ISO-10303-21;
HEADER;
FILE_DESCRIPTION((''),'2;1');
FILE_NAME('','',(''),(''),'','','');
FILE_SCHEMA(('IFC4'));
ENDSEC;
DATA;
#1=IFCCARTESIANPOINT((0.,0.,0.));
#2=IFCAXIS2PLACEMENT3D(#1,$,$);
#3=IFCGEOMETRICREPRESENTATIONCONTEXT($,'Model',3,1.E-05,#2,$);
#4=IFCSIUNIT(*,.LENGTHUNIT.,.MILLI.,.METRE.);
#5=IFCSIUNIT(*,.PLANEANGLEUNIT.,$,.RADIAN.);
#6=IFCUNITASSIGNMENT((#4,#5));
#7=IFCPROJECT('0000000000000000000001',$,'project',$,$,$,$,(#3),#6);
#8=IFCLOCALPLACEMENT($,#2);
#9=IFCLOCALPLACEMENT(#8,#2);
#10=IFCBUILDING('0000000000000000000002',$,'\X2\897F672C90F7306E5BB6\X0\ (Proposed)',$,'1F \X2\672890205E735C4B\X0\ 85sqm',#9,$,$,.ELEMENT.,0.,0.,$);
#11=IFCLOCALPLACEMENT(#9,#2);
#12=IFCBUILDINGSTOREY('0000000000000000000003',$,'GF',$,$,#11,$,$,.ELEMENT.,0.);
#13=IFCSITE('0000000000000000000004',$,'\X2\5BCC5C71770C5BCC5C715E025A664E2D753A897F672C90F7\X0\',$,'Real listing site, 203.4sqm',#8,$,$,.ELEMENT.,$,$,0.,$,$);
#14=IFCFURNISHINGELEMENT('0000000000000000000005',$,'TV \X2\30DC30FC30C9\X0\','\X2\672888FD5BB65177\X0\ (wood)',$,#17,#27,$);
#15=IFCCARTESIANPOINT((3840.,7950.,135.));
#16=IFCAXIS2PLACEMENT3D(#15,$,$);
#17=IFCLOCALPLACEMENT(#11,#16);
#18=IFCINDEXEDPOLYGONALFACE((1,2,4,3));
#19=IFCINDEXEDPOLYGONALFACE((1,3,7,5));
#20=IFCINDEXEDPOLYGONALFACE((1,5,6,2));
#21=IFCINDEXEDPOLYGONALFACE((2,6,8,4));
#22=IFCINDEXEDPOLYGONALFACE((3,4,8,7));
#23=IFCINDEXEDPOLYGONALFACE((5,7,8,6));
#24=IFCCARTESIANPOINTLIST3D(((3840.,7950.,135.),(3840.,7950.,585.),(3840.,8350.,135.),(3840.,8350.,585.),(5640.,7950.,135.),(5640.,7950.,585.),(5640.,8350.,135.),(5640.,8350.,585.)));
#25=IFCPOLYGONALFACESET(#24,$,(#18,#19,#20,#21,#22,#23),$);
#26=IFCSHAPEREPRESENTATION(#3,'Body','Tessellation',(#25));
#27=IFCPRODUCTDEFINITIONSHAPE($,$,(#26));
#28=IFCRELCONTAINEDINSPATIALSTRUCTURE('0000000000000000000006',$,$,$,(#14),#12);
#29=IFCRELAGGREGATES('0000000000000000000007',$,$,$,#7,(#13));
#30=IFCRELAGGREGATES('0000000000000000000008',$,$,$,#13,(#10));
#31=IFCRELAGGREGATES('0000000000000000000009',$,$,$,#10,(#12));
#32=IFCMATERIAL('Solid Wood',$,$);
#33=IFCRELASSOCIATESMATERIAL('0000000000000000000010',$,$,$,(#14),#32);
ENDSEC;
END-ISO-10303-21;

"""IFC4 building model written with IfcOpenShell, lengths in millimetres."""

from ifc_helpers import new_model, si_unit, frame, frame_2d, origin, place, context, project, spatial, rectangle, extrude, material, element, save


model = new_model("IFC4")

# Units and contexts
model_context = context("Model", 3, precision=1e-05, world=origin())
ifc_project = project(units=[si_unit("LENGTHUNIT", "METRE", prefix="MILLI"), si_unit("PLANEANGLEUNIT", "RADIAN")], contexts=[model_context])

# Site, building, storey
site_placement = place(None, origin())
site = spatial("IfcSite", under=ifc_project, at=site_placement, Name="富山県富山市婦中町西本郷", ObjectType="Real listing site, 203.4sqm", CompositionType="ELEMENT", RefElevation=0.0)
building_placement = place(site_placement, origin())
building = spatial("IfcBuilding", under=site, at=building_placement, Name="西本郷の家 (Proposed)", ObjectType="1F 木造平屋 85sqm", CompositionType="ELEMENT", ElevationOfRefHeight=0.0, ElevationOfTerrain=0.0)
storey_placement = place(building_placement, origin())
storey = spatial("IfcBuildingStorey", under=building, at=storey_placement, Name="GF", CompositionType="ELEMENT", Elevation=0.0)

# Shared definitions
ifc_material_1 = material(Name="Solid Wood")

# Furnishing element
furnishing_1_placement = place(storey_placement, frame((3840.0, 7950.0, 135.0)))
element("IfcFurnishingElement", 1, at=furnishing_1_placement, inside=storey, material=ifc_material_1, Name="TV ボード", Description="木製家具 (wood)", context=model_context, shape_type="SweptSolid", body=[
    extrude(rectangle(XDim=1800.0, YDim=400.0, at=frame_2d((900.0, 200.0))), frame((3840.0, 7950.0, 135.0)), (0.0, 0.0, 1.0), 450.0),
])

save(model, "model.ifc")
